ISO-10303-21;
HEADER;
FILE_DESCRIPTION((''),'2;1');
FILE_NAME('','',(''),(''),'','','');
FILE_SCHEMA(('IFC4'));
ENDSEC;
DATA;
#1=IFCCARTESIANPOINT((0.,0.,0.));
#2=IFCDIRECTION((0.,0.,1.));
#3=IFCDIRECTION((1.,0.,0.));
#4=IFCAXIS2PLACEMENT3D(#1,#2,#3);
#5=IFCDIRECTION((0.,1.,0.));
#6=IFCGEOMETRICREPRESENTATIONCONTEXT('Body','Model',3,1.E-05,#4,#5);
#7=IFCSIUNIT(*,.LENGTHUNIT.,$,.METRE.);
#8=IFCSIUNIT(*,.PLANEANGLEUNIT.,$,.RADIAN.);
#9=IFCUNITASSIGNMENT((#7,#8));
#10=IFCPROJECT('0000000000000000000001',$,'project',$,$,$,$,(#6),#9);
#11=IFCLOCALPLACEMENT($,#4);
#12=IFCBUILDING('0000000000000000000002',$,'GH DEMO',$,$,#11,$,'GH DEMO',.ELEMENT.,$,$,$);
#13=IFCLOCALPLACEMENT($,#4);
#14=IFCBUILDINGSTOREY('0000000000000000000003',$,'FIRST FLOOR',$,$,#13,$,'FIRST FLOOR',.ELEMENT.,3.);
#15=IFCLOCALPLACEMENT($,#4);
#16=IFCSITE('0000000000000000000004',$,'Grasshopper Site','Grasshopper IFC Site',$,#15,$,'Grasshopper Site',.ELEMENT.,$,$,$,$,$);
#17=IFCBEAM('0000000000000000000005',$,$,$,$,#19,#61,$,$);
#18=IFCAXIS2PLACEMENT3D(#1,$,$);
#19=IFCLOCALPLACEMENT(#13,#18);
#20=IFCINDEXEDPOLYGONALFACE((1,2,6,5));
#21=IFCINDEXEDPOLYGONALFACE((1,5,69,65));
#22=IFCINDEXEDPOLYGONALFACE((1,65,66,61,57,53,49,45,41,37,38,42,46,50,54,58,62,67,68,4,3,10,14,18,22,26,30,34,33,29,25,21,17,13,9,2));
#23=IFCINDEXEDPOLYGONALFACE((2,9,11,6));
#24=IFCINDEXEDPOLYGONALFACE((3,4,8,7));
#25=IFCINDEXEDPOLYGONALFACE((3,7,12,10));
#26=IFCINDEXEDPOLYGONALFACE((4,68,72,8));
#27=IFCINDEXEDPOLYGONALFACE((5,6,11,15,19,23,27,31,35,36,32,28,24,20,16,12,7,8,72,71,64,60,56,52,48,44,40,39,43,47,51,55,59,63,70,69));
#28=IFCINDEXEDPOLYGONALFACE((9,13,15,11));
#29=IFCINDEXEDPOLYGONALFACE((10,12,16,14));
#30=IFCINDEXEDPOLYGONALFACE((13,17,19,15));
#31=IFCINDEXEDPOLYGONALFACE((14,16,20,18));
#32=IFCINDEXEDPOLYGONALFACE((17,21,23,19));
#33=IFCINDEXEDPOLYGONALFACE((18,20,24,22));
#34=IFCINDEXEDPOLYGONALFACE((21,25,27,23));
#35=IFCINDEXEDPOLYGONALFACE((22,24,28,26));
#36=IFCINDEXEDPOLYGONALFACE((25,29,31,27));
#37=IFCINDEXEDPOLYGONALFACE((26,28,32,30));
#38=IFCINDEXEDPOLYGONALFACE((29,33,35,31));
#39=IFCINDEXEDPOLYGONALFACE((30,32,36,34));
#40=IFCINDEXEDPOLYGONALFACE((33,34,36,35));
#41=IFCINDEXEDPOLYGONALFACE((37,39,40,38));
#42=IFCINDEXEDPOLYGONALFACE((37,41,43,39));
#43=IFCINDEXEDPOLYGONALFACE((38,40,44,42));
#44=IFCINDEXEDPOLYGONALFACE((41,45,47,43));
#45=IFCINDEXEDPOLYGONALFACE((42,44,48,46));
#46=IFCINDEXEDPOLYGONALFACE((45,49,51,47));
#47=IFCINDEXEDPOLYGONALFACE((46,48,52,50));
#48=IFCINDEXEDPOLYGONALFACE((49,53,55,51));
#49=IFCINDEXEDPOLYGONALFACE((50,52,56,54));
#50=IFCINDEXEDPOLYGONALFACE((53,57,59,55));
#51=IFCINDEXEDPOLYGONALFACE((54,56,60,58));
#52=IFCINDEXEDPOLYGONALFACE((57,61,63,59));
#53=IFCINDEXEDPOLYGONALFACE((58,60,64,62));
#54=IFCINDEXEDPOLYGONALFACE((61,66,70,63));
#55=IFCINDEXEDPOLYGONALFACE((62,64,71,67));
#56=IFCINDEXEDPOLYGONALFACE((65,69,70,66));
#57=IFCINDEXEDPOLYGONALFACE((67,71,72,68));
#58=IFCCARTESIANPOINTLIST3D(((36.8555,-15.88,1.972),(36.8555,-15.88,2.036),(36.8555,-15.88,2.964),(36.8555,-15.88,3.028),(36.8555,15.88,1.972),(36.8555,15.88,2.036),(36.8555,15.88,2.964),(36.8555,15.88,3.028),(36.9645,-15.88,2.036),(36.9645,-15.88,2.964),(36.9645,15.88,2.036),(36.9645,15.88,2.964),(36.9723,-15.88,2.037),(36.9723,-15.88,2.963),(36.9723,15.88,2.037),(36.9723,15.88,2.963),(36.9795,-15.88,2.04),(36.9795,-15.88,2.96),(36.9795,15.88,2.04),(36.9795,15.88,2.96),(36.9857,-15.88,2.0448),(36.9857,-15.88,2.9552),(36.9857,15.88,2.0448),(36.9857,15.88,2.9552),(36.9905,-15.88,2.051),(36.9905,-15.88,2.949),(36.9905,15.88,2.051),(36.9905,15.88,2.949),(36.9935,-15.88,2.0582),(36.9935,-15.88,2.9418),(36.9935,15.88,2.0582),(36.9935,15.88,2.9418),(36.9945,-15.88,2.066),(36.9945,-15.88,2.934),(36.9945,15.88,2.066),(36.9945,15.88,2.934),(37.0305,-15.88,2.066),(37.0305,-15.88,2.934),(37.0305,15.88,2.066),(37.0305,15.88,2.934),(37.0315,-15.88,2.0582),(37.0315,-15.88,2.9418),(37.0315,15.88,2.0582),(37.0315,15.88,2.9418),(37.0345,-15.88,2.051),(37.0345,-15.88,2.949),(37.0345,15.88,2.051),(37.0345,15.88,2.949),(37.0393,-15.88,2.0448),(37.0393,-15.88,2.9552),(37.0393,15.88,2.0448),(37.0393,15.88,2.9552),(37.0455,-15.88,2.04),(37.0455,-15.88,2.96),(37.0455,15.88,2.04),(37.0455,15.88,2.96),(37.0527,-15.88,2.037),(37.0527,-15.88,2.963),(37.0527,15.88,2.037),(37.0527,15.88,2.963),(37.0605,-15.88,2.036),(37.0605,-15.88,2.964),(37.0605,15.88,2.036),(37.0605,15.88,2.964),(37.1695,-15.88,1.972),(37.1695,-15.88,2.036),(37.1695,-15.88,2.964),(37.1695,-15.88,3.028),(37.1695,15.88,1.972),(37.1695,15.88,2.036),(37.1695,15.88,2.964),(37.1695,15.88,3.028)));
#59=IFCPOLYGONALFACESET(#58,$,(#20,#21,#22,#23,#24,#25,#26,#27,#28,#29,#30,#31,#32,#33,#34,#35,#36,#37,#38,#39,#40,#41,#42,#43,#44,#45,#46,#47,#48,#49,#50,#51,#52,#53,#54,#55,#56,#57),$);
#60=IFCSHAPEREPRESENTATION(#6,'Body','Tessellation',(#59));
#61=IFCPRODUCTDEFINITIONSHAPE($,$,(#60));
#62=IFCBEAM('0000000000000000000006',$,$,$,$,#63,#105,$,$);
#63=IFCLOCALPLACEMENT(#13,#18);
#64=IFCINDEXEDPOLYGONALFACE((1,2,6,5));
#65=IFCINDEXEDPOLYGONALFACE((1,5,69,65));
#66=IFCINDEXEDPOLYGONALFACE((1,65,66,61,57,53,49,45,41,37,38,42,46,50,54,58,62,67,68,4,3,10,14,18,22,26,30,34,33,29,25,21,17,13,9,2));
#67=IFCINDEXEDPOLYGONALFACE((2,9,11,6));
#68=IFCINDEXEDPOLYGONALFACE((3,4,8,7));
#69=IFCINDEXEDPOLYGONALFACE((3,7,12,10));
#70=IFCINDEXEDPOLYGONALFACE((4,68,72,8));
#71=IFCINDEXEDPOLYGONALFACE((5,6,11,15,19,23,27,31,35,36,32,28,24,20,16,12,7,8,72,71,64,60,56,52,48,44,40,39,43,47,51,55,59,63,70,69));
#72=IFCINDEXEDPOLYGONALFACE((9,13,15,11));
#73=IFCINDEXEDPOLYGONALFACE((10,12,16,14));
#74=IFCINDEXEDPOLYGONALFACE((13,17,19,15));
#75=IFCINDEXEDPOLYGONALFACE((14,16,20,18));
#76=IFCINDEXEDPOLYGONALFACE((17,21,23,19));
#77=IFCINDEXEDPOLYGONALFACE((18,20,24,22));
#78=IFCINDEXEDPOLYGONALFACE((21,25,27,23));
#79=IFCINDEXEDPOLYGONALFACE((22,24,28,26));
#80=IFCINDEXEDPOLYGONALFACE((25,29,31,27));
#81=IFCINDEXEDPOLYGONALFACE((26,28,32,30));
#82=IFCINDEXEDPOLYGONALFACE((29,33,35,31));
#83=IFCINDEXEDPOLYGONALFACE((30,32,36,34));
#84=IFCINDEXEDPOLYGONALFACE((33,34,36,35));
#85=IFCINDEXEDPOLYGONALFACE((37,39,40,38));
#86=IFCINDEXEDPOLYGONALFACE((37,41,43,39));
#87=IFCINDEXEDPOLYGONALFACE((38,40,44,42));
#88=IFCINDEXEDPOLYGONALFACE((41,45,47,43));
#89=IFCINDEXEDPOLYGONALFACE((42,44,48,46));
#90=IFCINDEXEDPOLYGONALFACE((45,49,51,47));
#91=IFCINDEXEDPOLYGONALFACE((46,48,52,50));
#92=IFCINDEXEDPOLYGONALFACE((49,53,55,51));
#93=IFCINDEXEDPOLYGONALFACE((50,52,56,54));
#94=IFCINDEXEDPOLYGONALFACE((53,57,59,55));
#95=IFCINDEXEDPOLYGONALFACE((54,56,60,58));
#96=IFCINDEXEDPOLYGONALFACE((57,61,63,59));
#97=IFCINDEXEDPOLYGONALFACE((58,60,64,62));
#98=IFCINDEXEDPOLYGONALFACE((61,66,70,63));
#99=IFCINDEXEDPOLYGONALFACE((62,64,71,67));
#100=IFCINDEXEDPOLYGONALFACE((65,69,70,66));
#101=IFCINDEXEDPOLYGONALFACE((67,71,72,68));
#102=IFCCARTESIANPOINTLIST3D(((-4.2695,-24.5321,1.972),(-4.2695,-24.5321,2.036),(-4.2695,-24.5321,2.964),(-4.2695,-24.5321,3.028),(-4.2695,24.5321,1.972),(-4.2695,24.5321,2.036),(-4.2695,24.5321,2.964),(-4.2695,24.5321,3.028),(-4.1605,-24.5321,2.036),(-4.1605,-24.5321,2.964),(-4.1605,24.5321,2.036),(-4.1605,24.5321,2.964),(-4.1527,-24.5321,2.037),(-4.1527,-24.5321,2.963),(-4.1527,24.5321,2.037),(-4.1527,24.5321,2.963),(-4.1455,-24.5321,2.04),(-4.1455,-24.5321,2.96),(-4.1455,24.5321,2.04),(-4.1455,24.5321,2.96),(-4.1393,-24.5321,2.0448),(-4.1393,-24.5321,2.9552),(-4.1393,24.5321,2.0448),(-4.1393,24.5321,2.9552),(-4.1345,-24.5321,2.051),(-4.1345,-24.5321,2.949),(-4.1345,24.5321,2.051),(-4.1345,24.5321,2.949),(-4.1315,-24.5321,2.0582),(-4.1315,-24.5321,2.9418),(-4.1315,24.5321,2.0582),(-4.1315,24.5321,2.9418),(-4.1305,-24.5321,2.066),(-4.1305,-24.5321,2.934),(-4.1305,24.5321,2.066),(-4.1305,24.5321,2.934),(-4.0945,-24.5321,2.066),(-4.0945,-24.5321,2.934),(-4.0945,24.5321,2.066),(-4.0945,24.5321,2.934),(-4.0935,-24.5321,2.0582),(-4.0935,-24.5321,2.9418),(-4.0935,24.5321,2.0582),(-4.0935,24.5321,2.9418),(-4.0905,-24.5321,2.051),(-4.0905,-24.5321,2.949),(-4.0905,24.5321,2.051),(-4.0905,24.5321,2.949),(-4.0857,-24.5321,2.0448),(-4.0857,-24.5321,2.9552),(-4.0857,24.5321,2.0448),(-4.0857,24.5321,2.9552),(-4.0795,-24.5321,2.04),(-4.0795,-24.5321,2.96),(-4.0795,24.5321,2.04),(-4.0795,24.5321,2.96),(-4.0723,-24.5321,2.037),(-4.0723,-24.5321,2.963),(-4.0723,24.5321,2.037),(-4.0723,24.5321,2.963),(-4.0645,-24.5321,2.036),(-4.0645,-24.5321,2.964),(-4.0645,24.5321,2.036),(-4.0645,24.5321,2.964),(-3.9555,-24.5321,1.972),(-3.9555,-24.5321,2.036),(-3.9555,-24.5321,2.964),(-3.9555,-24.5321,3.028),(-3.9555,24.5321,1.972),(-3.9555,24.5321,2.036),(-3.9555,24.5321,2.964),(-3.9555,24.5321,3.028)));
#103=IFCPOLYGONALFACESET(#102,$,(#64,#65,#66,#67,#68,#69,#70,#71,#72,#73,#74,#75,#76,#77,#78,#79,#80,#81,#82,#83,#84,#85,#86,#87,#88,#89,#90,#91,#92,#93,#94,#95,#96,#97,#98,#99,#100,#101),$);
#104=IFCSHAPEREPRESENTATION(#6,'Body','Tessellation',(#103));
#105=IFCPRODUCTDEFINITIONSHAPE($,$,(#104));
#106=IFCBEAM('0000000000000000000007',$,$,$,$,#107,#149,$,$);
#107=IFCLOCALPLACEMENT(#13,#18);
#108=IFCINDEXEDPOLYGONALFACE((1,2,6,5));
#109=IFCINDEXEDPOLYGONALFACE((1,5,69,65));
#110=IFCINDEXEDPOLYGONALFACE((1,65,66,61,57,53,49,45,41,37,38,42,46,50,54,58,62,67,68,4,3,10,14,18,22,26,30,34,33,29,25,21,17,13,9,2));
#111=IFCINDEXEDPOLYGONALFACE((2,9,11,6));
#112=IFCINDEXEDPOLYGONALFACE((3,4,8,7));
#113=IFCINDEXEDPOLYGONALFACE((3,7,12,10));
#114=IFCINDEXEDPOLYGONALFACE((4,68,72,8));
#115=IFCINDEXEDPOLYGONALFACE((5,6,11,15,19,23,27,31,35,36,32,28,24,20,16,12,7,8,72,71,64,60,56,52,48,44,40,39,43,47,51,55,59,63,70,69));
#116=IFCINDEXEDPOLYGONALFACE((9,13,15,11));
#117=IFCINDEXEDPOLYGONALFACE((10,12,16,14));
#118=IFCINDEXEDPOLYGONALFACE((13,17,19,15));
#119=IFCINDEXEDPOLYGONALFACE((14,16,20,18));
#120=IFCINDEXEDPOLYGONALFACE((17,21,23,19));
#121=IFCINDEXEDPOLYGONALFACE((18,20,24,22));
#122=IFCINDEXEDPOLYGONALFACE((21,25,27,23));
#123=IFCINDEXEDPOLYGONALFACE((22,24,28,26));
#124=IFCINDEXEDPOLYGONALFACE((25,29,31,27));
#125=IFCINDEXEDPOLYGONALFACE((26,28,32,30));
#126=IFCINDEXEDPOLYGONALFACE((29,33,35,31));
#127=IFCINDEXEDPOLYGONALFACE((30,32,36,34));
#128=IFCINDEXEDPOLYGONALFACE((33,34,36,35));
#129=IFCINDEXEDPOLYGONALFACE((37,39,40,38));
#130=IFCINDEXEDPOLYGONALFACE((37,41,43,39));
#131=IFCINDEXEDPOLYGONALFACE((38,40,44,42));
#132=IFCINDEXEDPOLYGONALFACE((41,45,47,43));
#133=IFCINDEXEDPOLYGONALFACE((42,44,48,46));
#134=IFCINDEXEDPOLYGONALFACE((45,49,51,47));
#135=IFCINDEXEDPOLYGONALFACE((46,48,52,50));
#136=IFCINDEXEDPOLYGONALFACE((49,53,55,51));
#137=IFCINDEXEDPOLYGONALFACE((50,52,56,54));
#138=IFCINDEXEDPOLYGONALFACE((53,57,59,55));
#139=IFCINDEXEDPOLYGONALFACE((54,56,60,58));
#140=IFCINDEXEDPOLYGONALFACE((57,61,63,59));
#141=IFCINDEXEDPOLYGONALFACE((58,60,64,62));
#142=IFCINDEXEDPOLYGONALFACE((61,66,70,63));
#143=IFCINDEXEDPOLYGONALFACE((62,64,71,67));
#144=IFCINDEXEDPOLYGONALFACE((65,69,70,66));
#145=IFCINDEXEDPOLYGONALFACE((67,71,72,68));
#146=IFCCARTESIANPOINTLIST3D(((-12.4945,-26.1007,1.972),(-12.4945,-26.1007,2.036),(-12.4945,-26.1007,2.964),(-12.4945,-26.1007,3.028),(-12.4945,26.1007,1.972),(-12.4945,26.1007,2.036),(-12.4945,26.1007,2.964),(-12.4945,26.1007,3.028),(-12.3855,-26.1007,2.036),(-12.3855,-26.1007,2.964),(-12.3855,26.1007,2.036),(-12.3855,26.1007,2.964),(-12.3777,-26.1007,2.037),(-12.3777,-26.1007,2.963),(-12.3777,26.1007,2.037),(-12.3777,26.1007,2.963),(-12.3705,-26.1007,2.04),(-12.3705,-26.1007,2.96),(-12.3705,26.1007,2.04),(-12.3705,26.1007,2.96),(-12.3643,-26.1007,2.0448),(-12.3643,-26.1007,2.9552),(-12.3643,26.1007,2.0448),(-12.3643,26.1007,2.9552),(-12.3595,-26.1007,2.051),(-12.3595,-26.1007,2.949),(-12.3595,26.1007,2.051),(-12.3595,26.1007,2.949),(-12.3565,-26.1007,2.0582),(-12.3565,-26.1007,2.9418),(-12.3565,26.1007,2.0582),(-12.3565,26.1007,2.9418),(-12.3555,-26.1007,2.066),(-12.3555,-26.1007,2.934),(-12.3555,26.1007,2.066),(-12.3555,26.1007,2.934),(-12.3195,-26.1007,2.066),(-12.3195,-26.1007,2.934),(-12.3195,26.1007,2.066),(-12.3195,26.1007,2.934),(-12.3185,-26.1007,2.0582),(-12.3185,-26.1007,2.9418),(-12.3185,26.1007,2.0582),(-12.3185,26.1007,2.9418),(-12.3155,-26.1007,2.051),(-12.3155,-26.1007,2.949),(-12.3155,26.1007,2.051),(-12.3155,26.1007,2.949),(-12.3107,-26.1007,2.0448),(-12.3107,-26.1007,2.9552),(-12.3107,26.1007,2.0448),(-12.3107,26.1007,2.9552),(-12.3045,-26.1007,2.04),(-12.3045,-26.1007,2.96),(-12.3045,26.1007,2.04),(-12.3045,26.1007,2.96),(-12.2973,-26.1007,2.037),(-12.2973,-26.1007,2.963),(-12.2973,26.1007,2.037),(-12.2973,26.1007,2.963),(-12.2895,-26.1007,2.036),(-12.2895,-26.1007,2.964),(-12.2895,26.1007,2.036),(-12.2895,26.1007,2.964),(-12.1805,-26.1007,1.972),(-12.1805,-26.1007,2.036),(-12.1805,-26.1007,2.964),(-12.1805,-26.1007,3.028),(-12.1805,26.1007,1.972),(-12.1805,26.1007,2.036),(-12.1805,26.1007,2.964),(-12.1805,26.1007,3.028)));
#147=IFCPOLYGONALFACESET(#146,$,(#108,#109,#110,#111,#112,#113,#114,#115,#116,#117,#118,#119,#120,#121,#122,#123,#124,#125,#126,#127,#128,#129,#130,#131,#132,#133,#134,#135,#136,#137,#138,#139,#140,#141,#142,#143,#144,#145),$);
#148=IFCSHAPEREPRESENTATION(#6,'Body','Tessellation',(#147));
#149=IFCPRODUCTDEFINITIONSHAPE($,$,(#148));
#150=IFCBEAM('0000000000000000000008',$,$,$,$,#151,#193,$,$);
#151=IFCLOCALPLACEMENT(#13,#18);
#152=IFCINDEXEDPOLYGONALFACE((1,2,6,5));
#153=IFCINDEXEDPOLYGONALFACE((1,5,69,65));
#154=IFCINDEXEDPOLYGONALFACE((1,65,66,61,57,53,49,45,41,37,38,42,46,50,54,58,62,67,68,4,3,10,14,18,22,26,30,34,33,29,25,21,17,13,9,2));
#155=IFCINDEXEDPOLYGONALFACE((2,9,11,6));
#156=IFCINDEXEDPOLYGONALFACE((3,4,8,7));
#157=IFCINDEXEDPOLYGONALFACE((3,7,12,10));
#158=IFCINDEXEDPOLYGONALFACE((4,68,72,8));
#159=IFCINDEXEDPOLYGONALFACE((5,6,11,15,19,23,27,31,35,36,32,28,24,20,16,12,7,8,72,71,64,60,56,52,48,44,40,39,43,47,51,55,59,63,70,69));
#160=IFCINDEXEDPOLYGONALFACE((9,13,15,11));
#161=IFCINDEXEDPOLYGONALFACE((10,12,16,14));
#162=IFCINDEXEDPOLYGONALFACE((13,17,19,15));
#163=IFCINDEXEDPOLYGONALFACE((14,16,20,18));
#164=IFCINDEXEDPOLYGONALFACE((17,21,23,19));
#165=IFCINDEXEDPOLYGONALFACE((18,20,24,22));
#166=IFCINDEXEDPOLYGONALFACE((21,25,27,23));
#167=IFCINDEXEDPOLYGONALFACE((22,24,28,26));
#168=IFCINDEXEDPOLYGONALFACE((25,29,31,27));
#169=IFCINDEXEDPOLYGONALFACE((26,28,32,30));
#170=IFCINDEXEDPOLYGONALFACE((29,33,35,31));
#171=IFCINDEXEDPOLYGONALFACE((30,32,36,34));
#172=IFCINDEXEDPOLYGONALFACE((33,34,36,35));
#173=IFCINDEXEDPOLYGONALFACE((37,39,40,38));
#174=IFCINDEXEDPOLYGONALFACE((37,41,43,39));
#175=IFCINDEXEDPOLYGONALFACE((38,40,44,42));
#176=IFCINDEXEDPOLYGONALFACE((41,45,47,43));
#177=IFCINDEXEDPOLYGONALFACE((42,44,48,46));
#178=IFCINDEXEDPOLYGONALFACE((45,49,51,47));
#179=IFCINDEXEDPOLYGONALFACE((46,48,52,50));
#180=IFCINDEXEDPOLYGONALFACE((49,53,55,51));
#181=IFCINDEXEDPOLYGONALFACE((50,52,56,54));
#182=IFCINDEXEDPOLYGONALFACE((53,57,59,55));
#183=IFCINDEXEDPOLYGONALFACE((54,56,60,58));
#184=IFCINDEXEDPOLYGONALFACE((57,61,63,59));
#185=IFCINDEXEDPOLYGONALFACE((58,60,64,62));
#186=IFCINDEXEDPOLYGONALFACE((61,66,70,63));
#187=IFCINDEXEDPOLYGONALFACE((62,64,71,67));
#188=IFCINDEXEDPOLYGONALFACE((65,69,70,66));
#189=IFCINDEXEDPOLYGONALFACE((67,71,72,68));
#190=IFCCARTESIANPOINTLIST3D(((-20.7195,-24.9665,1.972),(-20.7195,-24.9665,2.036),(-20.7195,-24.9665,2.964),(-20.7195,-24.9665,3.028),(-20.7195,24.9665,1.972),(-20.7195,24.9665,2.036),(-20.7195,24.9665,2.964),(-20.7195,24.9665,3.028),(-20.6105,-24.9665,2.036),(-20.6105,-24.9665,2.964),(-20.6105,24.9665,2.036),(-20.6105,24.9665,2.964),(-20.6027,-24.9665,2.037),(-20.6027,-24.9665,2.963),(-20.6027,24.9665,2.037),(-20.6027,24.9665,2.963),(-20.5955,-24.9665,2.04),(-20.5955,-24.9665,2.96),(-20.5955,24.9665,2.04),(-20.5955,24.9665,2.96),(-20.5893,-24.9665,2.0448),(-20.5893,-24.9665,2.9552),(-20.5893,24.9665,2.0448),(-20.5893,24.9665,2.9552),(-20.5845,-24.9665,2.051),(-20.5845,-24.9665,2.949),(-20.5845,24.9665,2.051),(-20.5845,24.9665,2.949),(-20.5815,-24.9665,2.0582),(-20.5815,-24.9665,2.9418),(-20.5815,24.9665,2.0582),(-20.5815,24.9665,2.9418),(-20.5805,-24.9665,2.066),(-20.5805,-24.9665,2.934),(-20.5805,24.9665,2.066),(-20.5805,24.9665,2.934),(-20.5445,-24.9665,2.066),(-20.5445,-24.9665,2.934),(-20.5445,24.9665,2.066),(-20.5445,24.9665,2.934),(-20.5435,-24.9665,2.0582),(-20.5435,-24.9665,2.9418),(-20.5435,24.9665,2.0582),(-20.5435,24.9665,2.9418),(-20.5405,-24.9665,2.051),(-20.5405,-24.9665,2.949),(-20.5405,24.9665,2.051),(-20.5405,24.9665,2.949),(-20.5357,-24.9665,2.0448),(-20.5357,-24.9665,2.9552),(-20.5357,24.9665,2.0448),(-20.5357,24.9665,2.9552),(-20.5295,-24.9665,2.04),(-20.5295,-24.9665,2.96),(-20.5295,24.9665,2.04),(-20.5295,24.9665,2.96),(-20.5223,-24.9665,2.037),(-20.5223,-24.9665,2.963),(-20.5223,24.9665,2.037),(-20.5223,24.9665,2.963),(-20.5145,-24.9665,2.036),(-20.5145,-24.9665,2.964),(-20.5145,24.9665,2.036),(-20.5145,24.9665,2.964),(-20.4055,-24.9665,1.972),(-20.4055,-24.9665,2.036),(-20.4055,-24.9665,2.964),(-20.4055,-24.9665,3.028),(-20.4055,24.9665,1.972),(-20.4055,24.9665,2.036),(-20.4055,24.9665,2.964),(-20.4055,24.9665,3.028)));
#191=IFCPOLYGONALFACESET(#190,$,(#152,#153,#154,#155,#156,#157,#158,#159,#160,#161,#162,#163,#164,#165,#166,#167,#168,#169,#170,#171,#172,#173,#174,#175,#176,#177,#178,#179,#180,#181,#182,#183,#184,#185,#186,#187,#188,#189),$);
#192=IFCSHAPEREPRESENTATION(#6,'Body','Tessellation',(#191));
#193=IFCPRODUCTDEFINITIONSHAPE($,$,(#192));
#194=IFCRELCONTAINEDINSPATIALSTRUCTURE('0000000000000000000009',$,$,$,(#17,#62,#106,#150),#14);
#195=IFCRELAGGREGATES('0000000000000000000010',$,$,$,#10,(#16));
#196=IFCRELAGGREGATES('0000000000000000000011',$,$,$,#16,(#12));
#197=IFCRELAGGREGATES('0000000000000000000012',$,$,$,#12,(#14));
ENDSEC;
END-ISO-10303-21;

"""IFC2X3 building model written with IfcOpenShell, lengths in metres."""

from ifc_helpers import new_model, si_unit, direction, frame, origin_with_axes, origin_2d, place, context, project, spatial, i_section, extrude, element, save


model = new_model("IFC2X3")

# Units and contexts
model_context = context("Model", 3, precision=1e-05, world=origin_with_axes(), true_north=direction((0.0, 1.0, 0.0)), identifier="Body")
ifc_project = project(units=[si_unit("LENGTHUNIT", "METRE"), si_unit("PLANEANGLEUNIT", "RADIAN")], contexts=[model_context])

# Site, building, storey
site_placement = place(None, origin_with_axes())
site = spatial("IfcSite", under=ifc_project, at=site_placement, Name="Grasshopper Site", Description="Grasshopper IFC Site", LongName="Grasshopper Site", CompositionType="ELEMENT")
building_placement = place(None, origin_with_axes())
building = spatial("IfcBuilding", under=site, at=building_placement, Name="GH DEMO", LongName="GH DEMO", CompositionType="ELEMENT")
storey_placement = place(None, origin_with_axes())
storey = spatial("IfcBuildingStorey", under=building, at=storey_placement, Name="FIRST FLOOR", LongName="FIRST FLOOR", CompositionType="ELEMENT", Elevation=3.0)

# Beams
beam_1_placement = place(None, origin_with_axes())
element("IfcBeam", 1, at=beam_1_placement, inside=storey, context=model_context, shape_type="SweptSolid", body=[
    extrude(i_section(OverallWidth=0.314, OverallDepth=1.056, WebThickness=0.036, FlangeThickness=0.064, FilletRadius=0.03, at=origin_2d()), frame((37.0125, -15.88, 2.5), z_axis=(0.0, 1.0, 0.0), x_axis=(-1.0, 0.0, 0.0)), (0.0, 0.0, 1.0), 31.7599),
])
beam_2_placement = place(None, origin_with_axes())
element("IfcBeam", 2, at=beam_2_placement, inside=storey, context=model_context, shape_type="SweptSolid", body=[
    extrude(i_section(OverallWidth=0.314, OverallDepth=1.056, WebThickness=0.036, FlangeThickness=0.064, FilletRadius=0.03, at=origin_2d()), frame((-4.1125, -24.5321, 2.5), z_axis=(0.0, 1.0, 0.0), x_axis=(-1.0, 0.0, 0.0)), (0.0, 0.0, 1.0), 49.0642),
])
beam_3_placement = place(None, origin_with_axes())
element("IfcBeam", 3, at=beam_3_placement, inside=storey, context=model_context, shape_type="SweptSolid", body=[
    extrude(i_section(OverallWidth=0.314, OverallDepth=1.056, WebThickness=0.036, FlangeThickness=0.064, FilletRadius=0.03, at=origin_2d()), frame((-12.3375, -26.1007, 2.5), z_axis=(0.0, 1.0, 0.0), x_axis=(-1.0, 0.0, 0.0)), (0.0, 0.0, 1.0), 52.2014),
])
beam_4_placement = place(None, origin_with_axes())
element("IfcBeam", 4, at=beam_4_placement, inside=storey, context=model_context, shape_type="SweptSolid", body=[
    extrude(i_section(OverallWidth=0.314, OverallDepth=1.056, WebThickness=0.036, FlangeThickness=0.064, FilletRadius=0.03, at=origin_2d()), frame((-20.5625, -24.9665, 2.5), z_axis=(0.0, 1.0, 0.0), x_axis=(-1.0, 0.0, 0.0)), (0.0, 0.0, 1.0), 49.933),
])

save(model, "model.ifc")
